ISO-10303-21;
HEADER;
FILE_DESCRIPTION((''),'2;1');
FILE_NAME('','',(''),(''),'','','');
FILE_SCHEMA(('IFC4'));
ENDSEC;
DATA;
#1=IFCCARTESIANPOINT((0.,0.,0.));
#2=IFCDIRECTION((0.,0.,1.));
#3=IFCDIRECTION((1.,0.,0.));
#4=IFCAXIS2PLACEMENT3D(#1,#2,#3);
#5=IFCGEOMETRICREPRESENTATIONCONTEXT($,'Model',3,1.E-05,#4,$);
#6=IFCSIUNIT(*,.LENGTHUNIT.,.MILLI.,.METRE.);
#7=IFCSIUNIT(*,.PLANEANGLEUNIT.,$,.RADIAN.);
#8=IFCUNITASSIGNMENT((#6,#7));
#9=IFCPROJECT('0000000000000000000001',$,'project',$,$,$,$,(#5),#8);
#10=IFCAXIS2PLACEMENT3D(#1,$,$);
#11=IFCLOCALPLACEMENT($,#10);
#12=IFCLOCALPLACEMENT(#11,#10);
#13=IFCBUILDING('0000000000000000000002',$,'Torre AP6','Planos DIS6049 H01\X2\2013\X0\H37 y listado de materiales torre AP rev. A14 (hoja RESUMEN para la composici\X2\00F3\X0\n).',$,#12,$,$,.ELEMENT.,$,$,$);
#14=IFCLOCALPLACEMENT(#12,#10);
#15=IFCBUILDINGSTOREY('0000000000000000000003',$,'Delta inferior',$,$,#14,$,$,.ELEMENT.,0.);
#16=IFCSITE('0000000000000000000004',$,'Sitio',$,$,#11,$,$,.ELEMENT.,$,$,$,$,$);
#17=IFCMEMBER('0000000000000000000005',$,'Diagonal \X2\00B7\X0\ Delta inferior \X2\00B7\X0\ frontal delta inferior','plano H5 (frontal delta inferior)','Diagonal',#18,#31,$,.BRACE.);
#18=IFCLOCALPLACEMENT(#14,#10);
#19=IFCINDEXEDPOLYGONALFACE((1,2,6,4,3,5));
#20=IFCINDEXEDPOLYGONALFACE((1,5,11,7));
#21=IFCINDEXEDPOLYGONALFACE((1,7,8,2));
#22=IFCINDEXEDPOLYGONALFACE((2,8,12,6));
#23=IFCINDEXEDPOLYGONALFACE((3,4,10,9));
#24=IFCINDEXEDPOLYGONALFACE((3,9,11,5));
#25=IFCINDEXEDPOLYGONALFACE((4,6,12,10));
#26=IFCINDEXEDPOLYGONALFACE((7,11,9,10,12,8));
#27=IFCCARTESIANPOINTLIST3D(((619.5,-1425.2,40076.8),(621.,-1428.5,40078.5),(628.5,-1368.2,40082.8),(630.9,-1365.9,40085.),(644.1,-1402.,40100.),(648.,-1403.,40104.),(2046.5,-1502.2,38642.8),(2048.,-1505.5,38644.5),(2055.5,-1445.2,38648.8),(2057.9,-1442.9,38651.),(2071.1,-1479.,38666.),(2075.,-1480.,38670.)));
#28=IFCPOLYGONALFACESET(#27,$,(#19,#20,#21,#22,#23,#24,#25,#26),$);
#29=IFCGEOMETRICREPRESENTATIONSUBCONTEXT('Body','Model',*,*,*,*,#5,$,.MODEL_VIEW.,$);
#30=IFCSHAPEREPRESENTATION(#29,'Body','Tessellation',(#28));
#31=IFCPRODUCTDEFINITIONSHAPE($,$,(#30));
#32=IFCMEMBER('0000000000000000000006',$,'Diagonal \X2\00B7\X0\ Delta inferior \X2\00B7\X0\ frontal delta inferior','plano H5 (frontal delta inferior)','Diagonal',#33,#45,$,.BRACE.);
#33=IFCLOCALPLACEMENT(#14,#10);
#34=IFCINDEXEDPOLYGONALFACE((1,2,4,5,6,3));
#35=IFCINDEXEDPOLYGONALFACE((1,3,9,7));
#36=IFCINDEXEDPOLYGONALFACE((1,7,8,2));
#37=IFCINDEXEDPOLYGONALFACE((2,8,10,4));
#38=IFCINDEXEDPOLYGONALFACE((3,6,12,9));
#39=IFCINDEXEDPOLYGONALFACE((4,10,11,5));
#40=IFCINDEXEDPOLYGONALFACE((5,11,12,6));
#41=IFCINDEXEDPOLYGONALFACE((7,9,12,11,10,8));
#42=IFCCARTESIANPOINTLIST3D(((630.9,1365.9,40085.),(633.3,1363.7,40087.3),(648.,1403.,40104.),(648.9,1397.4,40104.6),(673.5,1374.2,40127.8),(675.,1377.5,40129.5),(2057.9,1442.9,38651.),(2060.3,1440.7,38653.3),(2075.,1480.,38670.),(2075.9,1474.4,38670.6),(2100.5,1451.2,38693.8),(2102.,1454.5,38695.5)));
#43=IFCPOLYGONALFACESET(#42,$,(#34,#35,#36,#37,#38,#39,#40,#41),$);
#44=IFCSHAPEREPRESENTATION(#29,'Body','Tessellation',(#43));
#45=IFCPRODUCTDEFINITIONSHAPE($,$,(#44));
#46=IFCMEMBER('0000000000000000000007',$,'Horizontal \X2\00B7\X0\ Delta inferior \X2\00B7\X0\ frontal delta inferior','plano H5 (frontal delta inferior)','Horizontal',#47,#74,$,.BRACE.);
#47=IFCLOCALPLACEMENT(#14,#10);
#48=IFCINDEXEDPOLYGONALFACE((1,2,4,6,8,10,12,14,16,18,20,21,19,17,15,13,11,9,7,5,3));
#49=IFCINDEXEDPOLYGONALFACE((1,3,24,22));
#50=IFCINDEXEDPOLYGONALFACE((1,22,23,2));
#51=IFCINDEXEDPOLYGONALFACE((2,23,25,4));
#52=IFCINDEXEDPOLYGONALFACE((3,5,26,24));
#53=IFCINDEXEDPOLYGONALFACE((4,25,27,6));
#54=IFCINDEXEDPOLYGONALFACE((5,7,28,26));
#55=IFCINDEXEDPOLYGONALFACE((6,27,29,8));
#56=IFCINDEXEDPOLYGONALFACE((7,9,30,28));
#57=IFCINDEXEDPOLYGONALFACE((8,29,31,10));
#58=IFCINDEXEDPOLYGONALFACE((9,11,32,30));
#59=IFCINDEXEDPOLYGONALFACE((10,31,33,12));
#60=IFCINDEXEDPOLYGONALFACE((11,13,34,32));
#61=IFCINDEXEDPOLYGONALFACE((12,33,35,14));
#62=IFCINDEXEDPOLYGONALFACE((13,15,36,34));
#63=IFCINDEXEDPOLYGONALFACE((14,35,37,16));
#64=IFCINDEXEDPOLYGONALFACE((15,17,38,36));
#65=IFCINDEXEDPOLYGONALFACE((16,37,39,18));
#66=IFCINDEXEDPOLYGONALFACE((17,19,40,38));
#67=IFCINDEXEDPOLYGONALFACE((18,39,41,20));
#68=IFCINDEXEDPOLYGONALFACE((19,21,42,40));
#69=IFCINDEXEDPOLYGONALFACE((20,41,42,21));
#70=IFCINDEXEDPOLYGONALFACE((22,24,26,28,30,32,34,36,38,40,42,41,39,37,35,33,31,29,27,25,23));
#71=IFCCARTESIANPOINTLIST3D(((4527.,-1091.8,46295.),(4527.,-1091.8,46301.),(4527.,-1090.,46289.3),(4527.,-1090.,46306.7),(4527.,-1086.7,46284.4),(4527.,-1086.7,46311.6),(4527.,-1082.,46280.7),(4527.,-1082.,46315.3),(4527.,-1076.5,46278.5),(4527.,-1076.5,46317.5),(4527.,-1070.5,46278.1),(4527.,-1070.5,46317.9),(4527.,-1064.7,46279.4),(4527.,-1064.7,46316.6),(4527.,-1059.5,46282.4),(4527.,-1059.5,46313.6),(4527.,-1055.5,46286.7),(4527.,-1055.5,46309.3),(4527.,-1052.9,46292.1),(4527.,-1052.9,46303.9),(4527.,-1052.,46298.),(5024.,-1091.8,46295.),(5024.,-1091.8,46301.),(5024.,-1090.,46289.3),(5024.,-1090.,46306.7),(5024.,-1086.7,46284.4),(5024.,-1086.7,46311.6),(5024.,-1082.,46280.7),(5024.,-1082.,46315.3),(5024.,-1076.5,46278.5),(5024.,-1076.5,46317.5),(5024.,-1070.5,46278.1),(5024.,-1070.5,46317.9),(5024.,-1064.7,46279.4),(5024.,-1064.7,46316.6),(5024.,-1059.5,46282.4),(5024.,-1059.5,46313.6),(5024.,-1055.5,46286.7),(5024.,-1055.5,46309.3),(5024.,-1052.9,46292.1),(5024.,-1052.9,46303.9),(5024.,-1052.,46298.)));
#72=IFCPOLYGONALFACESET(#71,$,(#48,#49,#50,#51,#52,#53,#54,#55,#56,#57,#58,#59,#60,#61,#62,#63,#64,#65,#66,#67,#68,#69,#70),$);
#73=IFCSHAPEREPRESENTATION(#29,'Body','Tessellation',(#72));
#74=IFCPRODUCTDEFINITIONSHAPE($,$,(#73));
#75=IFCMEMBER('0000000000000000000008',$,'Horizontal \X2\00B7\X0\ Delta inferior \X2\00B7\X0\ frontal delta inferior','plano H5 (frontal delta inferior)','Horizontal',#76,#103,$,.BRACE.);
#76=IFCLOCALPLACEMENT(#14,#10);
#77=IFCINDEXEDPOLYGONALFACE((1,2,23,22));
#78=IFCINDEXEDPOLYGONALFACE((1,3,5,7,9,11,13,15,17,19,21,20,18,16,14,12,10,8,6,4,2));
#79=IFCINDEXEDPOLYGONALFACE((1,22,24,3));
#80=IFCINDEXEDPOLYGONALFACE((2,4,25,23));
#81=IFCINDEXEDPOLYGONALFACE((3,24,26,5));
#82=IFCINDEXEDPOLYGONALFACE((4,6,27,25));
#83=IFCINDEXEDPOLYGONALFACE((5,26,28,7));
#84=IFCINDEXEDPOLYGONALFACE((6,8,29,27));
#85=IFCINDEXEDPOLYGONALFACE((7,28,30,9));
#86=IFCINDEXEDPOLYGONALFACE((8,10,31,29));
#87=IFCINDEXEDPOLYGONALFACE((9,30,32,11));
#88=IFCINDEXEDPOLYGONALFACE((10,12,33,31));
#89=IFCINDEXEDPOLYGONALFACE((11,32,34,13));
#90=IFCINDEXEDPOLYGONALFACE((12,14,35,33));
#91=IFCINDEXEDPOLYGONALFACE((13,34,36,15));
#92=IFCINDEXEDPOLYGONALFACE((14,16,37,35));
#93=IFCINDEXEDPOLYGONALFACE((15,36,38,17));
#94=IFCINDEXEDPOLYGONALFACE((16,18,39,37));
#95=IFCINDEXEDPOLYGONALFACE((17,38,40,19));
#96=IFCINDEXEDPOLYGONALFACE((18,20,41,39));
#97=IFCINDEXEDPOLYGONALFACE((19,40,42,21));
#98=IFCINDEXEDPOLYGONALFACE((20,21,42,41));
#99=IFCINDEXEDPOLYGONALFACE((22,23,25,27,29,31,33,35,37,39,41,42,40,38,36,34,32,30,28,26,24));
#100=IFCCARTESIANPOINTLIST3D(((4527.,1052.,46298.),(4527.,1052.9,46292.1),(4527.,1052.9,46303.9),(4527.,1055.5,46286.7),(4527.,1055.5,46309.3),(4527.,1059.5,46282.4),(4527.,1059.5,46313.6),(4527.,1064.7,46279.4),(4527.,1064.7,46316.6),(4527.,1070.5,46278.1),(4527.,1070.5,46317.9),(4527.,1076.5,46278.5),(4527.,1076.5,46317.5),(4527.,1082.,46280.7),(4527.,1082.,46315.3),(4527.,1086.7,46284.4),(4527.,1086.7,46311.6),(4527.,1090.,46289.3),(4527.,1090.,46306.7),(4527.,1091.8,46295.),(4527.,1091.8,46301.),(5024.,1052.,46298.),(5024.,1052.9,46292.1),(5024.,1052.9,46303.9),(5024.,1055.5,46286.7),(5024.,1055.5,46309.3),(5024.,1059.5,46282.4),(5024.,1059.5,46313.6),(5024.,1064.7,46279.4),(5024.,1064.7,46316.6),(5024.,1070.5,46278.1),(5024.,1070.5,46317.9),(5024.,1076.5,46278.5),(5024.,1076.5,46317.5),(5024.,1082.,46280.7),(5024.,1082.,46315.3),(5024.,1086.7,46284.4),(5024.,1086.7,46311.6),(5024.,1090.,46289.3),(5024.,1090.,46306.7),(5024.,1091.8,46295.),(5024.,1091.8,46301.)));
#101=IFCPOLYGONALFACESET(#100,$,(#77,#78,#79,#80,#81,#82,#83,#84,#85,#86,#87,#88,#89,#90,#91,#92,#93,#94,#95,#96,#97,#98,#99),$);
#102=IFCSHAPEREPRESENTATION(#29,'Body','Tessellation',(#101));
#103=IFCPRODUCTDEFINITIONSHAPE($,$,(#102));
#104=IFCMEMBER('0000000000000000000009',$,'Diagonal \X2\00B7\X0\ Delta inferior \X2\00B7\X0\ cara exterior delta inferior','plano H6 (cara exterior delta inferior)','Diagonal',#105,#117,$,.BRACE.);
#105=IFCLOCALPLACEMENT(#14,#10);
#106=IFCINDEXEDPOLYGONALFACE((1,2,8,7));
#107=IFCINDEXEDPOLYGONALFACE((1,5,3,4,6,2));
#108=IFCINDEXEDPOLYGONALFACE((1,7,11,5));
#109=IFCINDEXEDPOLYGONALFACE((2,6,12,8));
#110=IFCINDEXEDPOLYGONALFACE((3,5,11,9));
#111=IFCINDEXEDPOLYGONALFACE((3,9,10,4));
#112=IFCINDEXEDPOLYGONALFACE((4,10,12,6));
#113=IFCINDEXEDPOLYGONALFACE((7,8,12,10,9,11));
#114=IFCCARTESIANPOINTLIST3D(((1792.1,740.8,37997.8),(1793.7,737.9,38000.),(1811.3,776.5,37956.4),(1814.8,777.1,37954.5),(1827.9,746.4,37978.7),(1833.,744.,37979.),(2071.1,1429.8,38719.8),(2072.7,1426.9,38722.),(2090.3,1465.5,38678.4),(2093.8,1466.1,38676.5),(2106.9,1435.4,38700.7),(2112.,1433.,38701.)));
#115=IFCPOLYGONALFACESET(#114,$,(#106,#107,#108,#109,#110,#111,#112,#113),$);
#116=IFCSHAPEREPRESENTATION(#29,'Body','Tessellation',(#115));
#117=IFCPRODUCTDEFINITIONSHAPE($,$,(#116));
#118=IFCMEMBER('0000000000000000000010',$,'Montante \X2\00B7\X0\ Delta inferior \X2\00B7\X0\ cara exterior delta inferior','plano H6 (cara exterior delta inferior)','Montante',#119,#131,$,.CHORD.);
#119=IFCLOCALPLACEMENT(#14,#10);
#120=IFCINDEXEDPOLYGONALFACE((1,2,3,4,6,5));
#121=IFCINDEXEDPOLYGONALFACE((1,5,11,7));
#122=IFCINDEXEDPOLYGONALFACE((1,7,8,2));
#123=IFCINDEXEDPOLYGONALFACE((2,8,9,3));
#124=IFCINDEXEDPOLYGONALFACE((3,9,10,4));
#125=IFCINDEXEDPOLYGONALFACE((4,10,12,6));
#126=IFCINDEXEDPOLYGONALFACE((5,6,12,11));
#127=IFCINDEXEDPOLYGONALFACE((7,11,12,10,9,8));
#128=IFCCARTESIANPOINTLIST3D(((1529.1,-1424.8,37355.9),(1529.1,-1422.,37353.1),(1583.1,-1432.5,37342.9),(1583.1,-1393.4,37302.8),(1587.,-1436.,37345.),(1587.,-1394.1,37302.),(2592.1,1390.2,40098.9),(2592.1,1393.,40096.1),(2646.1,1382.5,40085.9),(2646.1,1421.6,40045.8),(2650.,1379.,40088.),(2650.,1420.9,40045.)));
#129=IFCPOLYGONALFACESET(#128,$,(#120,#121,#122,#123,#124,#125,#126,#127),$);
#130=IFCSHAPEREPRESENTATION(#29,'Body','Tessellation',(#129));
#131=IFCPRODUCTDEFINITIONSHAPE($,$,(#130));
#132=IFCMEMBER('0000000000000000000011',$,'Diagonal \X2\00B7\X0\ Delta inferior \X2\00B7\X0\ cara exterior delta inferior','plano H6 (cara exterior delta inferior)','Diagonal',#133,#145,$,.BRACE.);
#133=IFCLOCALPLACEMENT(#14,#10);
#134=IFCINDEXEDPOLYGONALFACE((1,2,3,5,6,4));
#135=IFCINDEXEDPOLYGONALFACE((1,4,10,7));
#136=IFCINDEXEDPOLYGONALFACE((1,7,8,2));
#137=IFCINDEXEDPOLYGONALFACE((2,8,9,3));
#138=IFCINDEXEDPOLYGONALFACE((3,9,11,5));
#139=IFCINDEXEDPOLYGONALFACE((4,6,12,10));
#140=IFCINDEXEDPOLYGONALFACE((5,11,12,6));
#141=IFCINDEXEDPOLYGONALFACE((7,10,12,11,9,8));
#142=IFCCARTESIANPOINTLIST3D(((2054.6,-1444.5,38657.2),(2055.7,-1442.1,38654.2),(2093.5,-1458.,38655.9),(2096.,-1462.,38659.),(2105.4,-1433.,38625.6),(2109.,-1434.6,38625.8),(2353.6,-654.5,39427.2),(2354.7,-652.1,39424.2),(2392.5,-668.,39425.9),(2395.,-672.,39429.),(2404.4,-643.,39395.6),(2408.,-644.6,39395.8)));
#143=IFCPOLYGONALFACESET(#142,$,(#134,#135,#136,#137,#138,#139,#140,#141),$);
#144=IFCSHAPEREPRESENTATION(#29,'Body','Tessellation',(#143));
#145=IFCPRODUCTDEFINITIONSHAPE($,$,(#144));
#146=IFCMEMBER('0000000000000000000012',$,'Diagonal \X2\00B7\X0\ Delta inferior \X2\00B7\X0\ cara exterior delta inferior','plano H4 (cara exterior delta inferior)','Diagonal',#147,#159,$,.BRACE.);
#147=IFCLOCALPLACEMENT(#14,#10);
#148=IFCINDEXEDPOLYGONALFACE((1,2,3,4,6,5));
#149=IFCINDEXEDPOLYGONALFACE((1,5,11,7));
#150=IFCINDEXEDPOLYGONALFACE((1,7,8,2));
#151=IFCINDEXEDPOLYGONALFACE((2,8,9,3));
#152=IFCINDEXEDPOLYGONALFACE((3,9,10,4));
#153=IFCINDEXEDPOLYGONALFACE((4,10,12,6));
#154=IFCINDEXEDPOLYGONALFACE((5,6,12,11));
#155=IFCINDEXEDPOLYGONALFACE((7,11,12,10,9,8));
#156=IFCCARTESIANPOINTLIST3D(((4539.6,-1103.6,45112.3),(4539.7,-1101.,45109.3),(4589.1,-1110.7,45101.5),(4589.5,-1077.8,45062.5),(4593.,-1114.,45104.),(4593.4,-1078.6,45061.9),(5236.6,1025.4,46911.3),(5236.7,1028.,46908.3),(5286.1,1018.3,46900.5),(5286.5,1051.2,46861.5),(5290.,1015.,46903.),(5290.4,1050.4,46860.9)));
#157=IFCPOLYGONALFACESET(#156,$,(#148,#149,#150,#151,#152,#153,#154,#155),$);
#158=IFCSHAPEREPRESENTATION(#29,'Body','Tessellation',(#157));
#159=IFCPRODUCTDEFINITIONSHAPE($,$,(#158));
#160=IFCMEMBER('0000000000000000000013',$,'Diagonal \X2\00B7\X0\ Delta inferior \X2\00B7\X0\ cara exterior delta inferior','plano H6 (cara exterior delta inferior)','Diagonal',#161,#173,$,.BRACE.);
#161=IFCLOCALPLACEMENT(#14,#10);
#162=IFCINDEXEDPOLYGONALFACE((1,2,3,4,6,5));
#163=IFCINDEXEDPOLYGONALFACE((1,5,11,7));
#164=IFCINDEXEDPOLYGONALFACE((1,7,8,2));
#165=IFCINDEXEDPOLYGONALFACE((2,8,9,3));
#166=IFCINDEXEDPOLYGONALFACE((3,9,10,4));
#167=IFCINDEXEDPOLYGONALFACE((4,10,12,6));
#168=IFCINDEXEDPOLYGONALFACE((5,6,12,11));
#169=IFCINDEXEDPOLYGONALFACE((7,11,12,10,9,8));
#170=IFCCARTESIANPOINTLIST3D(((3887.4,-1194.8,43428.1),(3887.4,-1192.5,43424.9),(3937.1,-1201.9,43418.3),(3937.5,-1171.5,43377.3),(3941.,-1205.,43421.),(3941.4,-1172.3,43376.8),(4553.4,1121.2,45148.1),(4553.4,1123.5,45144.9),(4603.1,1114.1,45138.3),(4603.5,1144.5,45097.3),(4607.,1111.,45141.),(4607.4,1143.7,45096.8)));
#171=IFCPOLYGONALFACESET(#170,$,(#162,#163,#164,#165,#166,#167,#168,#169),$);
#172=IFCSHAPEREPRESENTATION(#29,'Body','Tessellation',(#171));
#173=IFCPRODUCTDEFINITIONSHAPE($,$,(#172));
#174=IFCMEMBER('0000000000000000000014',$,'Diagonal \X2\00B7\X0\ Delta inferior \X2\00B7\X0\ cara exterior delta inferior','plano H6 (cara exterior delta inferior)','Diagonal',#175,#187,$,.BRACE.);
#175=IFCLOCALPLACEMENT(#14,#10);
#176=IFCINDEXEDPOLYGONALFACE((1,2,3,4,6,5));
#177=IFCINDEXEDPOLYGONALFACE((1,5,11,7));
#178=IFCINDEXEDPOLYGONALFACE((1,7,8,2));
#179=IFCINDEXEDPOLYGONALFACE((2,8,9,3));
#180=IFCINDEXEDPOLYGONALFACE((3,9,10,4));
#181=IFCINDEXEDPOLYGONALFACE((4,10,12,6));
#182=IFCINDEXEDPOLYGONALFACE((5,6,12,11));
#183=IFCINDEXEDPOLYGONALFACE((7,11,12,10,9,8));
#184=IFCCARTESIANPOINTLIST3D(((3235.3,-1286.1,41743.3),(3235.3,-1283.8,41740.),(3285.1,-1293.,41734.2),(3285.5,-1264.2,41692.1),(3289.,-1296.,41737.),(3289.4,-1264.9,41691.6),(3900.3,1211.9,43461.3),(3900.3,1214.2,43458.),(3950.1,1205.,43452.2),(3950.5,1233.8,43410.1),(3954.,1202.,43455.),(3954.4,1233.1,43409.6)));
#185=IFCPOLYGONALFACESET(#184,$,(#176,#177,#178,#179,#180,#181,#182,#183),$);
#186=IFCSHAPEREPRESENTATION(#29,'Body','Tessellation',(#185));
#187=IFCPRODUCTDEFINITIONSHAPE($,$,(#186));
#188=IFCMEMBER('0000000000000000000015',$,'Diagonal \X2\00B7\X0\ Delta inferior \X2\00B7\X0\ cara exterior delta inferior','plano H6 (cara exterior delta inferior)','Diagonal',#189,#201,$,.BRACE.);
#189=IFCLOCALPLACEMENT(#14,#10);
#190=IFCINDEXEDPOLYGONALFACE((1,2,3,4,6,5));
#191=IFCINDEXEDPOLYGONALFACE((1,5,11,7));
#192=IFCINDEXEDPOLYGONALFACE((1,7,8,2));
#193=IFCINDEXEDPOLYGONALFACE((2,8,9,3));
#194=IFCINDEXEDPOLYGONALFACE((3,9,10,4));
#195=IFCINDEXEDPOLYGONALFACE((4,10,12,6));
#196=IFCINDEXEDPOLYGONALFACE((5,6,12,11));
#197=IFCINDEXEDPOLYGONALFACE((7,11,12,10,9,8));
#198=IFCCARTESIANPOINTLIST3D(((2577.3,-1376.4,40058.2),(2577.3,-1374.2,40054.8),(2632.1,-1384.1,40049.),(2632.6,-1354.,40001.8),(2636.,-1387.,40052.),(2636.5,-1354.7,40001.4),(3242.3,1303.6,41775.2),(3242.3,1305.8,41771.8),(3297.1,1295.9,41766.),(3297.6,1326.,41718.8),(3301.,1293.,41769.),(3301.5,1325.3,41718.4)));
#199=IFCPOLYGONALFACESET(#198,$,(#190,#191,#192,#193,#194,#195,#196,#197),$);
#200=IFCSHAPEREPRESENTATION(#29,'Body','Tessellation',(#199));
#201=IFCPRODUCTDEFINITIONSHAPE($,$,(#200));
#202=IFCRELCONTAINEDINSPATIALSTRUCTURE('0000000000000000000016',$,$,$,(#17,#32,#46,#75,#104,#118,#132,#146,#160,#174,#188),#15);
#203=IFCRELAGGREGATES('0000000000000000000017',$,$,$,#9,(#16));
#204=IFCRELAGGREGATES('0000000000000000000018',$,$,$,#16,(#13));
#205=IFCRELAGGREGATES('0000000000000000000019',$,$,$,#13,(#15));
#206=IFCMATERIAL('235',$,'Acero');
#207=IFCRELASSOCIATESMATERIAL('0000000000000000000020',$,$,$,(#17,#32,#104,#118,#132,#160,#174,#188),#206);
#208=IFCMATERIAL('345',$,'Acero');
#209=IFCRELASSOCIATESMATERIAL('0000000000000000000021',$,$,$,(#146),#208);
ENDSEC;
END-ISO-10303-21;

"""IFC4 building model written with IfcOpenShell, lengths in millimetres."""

from ifc_helpers import new_model, si_unit, frame, frame_2d, origin, origin_with_axes, place, context, subcontext, project, spatial, circle, l_section, extrude, material, element, save


model = new_model("IFC4")

# Units and contexts
model_context = context("Model", 3, precision=1e-05, world=origin_with_axes())
body_context = subcontext(model_context, "Body", "Model", "MODEL_VIEW")
ifc_project = project(units=[si_unit("LENGTHUNIT", "METRE", prefix="MILLI"), si_unit("PLANEANGLEUNIT", "RADIAN")], contexts=[model_context])

# Site, building, storey
site_placement = place(None, origin())
site = spatial("IfcSite", under=ifc_project, at=site_placement, Name="Sitio", CompositionType="ELEMENT")
building_placement = place(site_placement, origin())
building = spatial("IfcBuilding", under=site, at=building_placement, Name="Torre AP6", Description="Planos DIS6049 H01–H37 y listado de materiales torre AP rev. A14 (hoja RESUMEN para la composición).", CompositionType="ELEMENT")
storey_placement = place(building_placement, origin())
storey = spatial("IfcBuildingStorey", under=building, at=storey_placement, Name="Delta inferior", CompositionType="ELEMENT", Elevation=0.0)

# Members
ifc_material_1 = material(Name="235", Category="Acero")
for number, where, z_axis, x_axis, name in (
    (1, (2075.0, -1480.0, 38670.0), (-0.704864, 0.038034, 0.708322), (-0.379432, 0.82348, -0.421797), "Diagonal · Delta inferior · frontal delta inferior"),
    (2, (2075.0, 1480.0, 38670.0), (-0.704864, -0.038034, 0.708322), (-0.379432, -0.82348, -0.421797), "Diagonal · Delta inferior · frontal delta inferior"),
):
    element("IfcMember", number, at=place(storey_placement, frame(where, z_axis=z_axis, x_axis=x_axis)), inside=storey, material=ifc_material_1, Name=name, Description="plano H5 (frontal delta inferior)", ObjectType="Diagonal", PredefinedType="BRACE", context=body_context, shape_type="SweptSolid", body=[
        extrude(l_section(Depth=45.0, Width=45.0, Thickness=4.0, at=frame_2d((22.5, 22.5))), None, (0.0, 0.0, 1.0), 2024.5),
    ])
for number, where, z_axis, x_axis, name in (
    (3, (5024.0, -1072.0, 46298.0), (-1.0, 0.0, 0.0), (0.0, 1.0, 0.0), "Horizontal · Delta inferior · frontal delta inferior"),
    (4, (5024.0, 1072.0, 46298.0), (-1.0, 0.0, 0.0), (0.0, -1.0, 0.0), "Horizontal · Delta inferior · frontal delta inferior"),
):
    element("IfcMember", number, at=place(storey_placement, frame(where, z_axis=z_axis, x_axis=x_axis)), inside=storey, Name=name, Description="plano H5 (frontal delta inferior)", ObjectType="Horizontal", PredefinedType="BRACE", context=body_context, shape_type="SweptSolid", body=[
        extrude(circle(Radius=20.0), None, (0.0, 0.0, 1.0), 497.0),
    ])
member_1_placement = place(storey_placement, frame((2112.0, 1433.0, 38701.0), z_axis=(-0.269236, -0.664888, -0.696733), x_axis=(-0.873631, -0.135855, 0.46724)))
element("IfcMember", 5, at=member_1_placement, inside=storey, material=ifc_material_1, Name="Diagonal · Delta inferior · cara exterior delta inferior", Description="plano H6 (cara exterior delta inferior)", ObjectType="Diagonal", PredefinedType="BRACE", context=body_context, shape_type="SweptSolid", body=[
    extrude(l_section(Depth=45.0, Width=45.0, Thickness=4.0, at=frame_2d((22.5, 22.5))), None, (0.0, 0.0, 1.0), 1036.3),
])
member_2_placement = place(storey_placement, frame((2650.0, 1379.0, 40088.0), z_axis=(-0.261074, -0.691368, -0.673685), x_axis=(-0.965319, 0.186983, 0.182201)))
element("IfcMember", 6, at=member_2_placement, inside=storey, material=ifc_material_1, Name="Montante · Delta inferior · cara exterior delta inferior", Description="plano H6 (cara exterior delta inferior)", ObjectType="Montante", PredefinedType="CHORD", context=body_context, shape_type="SweptSolid", body=[
    extrude(l_section(Depth=60.0, Width=60.0, Thickness=4.0, at=frame_2d((30.0, 30.0))), None, (0.0, 0.0, 1.0), 4071.6),
])
member_3_placement = place(storey_placement, frame((2395.0, -672.0, 39429.0), z_axis=(-0.261597, -0.691176, -0.673678), x_axis=(-0.920687, 0.38817, -0.040739)))
element("IfcMember", 7, at=member_3_placement, inside=storey, material=ifc_material_1, Name="Diagonal · Delta inferior · cara exterior delta inferior", Description="plano H6 (cara exterior delta inferior)", ObjectType="Diagonal", PredefinedType="BRACE", context=body_context, shape_type="SweptSolid", body=[
    extrude(l_section(Depth=45.0, Width=45.0, Thickness=4.0, at=frame_2d((22.5, 22.5))), None, (0.0, 0.0, 1.0), 1143.0),
])
ifc_material_2 = material(Name="345", Category="Acero")
member_4_placement = place(storey_placement, frame((5290.0, 1015.0, 46903.0), z_axis=(-0.242593, -0.741005, -0.626147), x_axis=(-0.970107, 0.189587, 0.151492)))
element("IfcMember", 8, at=member_4_placement, inside=storey, material=ifc_material_2, Name="Diagonal · Delta inferior · cara exterior delta inferior", Description="plano H4 (cara exterior delta inferior)", ObjectType="Diagonal", PredefinedType="BRACE", context=body_context, shape_type="SweptSolid", body=[
    extrude(l_section(Depth=55.0, Width=55.0, Thickness=4.0, at=frame_2d((27.5, 27.5))), None, (0.0, 0.0, 1.0), 2873.1),
])
member_5_placement = place(storey_placement, frame((4607.0, 1111.0, 45141.0), z_axis=(-0.224946, -0.782244, -0.580941), x_axis=(-0.974349, 0.184591, 0.128724)))
element("IfcMember", 9, at=member_5_placement, inside=storey, material=ifc_material_1, Name="Diagonal · Delta inferior · cara exterior delta inferior", Description="plano H6 (cara exterior delta inferior)", ObjectType="Diagonal", PredefinedType="BRACE", context=body_context, shape_type="SweptSolid", body=[
    extrude(l_section(Depth=55.0, Width=55.0, Thickness=4.0, at=frame_2d((27.5, 27.5))), None, (0.0, 0.0, 1.0), 2960.7),
])
member_6_placement = place(storey_placement, frame((3954.0, 1202.0, 43455.0), z_axis=(-0.214252, -0.804812, -0.55351), x_axis=(-0.976751, 0.180783, 0.115217)))
element("IfcMember", 10, at=member_6_placement, inside=storey, material=ifc_material_1, Name="Diagonal · Delta inferior · cara exterior delta inferior", Description="plano H6 (cara exterior delta inferior)", ObjectType="Diagonal", PredefinedType="BRACE", context=body_context, shape_type="SweptSolid", body=[
    extrude(l_section(Depth=55.0, Width=55.0, Thickness=4.0, at=frame_2d((27.5, 27.5))), None, (0.0, 0.0, 1.0), 3103.8),
])
member_7_placement = place(storey_placement, frame((3301.0, 1293.0, 41769.0), z_axis=(-0.204517, -0.824217, -0.528052), x_axis=(-0.978826, 0.176893, 0.102997)))
element("IfcMember", 11, at=member_7_placement, inside=storey, material=ifc_material_1, Name="Diagonal · Delta inferior · cara exterior delta inferior", Description="plano H6 (cara exterior delta inferior)", ObjectType="Diagonal", PredefinedType="BRACE", context=body_context, shape_type="SweptSolid", body=[
    extrude(l_section(Depth=60.0, Width=60.0, Thickness=4.0, at=frame_2d((30.0, 30.0))), None, (0.0, 0.0, 1.0), 3251.6),
])

save(model, "model.ifc")
